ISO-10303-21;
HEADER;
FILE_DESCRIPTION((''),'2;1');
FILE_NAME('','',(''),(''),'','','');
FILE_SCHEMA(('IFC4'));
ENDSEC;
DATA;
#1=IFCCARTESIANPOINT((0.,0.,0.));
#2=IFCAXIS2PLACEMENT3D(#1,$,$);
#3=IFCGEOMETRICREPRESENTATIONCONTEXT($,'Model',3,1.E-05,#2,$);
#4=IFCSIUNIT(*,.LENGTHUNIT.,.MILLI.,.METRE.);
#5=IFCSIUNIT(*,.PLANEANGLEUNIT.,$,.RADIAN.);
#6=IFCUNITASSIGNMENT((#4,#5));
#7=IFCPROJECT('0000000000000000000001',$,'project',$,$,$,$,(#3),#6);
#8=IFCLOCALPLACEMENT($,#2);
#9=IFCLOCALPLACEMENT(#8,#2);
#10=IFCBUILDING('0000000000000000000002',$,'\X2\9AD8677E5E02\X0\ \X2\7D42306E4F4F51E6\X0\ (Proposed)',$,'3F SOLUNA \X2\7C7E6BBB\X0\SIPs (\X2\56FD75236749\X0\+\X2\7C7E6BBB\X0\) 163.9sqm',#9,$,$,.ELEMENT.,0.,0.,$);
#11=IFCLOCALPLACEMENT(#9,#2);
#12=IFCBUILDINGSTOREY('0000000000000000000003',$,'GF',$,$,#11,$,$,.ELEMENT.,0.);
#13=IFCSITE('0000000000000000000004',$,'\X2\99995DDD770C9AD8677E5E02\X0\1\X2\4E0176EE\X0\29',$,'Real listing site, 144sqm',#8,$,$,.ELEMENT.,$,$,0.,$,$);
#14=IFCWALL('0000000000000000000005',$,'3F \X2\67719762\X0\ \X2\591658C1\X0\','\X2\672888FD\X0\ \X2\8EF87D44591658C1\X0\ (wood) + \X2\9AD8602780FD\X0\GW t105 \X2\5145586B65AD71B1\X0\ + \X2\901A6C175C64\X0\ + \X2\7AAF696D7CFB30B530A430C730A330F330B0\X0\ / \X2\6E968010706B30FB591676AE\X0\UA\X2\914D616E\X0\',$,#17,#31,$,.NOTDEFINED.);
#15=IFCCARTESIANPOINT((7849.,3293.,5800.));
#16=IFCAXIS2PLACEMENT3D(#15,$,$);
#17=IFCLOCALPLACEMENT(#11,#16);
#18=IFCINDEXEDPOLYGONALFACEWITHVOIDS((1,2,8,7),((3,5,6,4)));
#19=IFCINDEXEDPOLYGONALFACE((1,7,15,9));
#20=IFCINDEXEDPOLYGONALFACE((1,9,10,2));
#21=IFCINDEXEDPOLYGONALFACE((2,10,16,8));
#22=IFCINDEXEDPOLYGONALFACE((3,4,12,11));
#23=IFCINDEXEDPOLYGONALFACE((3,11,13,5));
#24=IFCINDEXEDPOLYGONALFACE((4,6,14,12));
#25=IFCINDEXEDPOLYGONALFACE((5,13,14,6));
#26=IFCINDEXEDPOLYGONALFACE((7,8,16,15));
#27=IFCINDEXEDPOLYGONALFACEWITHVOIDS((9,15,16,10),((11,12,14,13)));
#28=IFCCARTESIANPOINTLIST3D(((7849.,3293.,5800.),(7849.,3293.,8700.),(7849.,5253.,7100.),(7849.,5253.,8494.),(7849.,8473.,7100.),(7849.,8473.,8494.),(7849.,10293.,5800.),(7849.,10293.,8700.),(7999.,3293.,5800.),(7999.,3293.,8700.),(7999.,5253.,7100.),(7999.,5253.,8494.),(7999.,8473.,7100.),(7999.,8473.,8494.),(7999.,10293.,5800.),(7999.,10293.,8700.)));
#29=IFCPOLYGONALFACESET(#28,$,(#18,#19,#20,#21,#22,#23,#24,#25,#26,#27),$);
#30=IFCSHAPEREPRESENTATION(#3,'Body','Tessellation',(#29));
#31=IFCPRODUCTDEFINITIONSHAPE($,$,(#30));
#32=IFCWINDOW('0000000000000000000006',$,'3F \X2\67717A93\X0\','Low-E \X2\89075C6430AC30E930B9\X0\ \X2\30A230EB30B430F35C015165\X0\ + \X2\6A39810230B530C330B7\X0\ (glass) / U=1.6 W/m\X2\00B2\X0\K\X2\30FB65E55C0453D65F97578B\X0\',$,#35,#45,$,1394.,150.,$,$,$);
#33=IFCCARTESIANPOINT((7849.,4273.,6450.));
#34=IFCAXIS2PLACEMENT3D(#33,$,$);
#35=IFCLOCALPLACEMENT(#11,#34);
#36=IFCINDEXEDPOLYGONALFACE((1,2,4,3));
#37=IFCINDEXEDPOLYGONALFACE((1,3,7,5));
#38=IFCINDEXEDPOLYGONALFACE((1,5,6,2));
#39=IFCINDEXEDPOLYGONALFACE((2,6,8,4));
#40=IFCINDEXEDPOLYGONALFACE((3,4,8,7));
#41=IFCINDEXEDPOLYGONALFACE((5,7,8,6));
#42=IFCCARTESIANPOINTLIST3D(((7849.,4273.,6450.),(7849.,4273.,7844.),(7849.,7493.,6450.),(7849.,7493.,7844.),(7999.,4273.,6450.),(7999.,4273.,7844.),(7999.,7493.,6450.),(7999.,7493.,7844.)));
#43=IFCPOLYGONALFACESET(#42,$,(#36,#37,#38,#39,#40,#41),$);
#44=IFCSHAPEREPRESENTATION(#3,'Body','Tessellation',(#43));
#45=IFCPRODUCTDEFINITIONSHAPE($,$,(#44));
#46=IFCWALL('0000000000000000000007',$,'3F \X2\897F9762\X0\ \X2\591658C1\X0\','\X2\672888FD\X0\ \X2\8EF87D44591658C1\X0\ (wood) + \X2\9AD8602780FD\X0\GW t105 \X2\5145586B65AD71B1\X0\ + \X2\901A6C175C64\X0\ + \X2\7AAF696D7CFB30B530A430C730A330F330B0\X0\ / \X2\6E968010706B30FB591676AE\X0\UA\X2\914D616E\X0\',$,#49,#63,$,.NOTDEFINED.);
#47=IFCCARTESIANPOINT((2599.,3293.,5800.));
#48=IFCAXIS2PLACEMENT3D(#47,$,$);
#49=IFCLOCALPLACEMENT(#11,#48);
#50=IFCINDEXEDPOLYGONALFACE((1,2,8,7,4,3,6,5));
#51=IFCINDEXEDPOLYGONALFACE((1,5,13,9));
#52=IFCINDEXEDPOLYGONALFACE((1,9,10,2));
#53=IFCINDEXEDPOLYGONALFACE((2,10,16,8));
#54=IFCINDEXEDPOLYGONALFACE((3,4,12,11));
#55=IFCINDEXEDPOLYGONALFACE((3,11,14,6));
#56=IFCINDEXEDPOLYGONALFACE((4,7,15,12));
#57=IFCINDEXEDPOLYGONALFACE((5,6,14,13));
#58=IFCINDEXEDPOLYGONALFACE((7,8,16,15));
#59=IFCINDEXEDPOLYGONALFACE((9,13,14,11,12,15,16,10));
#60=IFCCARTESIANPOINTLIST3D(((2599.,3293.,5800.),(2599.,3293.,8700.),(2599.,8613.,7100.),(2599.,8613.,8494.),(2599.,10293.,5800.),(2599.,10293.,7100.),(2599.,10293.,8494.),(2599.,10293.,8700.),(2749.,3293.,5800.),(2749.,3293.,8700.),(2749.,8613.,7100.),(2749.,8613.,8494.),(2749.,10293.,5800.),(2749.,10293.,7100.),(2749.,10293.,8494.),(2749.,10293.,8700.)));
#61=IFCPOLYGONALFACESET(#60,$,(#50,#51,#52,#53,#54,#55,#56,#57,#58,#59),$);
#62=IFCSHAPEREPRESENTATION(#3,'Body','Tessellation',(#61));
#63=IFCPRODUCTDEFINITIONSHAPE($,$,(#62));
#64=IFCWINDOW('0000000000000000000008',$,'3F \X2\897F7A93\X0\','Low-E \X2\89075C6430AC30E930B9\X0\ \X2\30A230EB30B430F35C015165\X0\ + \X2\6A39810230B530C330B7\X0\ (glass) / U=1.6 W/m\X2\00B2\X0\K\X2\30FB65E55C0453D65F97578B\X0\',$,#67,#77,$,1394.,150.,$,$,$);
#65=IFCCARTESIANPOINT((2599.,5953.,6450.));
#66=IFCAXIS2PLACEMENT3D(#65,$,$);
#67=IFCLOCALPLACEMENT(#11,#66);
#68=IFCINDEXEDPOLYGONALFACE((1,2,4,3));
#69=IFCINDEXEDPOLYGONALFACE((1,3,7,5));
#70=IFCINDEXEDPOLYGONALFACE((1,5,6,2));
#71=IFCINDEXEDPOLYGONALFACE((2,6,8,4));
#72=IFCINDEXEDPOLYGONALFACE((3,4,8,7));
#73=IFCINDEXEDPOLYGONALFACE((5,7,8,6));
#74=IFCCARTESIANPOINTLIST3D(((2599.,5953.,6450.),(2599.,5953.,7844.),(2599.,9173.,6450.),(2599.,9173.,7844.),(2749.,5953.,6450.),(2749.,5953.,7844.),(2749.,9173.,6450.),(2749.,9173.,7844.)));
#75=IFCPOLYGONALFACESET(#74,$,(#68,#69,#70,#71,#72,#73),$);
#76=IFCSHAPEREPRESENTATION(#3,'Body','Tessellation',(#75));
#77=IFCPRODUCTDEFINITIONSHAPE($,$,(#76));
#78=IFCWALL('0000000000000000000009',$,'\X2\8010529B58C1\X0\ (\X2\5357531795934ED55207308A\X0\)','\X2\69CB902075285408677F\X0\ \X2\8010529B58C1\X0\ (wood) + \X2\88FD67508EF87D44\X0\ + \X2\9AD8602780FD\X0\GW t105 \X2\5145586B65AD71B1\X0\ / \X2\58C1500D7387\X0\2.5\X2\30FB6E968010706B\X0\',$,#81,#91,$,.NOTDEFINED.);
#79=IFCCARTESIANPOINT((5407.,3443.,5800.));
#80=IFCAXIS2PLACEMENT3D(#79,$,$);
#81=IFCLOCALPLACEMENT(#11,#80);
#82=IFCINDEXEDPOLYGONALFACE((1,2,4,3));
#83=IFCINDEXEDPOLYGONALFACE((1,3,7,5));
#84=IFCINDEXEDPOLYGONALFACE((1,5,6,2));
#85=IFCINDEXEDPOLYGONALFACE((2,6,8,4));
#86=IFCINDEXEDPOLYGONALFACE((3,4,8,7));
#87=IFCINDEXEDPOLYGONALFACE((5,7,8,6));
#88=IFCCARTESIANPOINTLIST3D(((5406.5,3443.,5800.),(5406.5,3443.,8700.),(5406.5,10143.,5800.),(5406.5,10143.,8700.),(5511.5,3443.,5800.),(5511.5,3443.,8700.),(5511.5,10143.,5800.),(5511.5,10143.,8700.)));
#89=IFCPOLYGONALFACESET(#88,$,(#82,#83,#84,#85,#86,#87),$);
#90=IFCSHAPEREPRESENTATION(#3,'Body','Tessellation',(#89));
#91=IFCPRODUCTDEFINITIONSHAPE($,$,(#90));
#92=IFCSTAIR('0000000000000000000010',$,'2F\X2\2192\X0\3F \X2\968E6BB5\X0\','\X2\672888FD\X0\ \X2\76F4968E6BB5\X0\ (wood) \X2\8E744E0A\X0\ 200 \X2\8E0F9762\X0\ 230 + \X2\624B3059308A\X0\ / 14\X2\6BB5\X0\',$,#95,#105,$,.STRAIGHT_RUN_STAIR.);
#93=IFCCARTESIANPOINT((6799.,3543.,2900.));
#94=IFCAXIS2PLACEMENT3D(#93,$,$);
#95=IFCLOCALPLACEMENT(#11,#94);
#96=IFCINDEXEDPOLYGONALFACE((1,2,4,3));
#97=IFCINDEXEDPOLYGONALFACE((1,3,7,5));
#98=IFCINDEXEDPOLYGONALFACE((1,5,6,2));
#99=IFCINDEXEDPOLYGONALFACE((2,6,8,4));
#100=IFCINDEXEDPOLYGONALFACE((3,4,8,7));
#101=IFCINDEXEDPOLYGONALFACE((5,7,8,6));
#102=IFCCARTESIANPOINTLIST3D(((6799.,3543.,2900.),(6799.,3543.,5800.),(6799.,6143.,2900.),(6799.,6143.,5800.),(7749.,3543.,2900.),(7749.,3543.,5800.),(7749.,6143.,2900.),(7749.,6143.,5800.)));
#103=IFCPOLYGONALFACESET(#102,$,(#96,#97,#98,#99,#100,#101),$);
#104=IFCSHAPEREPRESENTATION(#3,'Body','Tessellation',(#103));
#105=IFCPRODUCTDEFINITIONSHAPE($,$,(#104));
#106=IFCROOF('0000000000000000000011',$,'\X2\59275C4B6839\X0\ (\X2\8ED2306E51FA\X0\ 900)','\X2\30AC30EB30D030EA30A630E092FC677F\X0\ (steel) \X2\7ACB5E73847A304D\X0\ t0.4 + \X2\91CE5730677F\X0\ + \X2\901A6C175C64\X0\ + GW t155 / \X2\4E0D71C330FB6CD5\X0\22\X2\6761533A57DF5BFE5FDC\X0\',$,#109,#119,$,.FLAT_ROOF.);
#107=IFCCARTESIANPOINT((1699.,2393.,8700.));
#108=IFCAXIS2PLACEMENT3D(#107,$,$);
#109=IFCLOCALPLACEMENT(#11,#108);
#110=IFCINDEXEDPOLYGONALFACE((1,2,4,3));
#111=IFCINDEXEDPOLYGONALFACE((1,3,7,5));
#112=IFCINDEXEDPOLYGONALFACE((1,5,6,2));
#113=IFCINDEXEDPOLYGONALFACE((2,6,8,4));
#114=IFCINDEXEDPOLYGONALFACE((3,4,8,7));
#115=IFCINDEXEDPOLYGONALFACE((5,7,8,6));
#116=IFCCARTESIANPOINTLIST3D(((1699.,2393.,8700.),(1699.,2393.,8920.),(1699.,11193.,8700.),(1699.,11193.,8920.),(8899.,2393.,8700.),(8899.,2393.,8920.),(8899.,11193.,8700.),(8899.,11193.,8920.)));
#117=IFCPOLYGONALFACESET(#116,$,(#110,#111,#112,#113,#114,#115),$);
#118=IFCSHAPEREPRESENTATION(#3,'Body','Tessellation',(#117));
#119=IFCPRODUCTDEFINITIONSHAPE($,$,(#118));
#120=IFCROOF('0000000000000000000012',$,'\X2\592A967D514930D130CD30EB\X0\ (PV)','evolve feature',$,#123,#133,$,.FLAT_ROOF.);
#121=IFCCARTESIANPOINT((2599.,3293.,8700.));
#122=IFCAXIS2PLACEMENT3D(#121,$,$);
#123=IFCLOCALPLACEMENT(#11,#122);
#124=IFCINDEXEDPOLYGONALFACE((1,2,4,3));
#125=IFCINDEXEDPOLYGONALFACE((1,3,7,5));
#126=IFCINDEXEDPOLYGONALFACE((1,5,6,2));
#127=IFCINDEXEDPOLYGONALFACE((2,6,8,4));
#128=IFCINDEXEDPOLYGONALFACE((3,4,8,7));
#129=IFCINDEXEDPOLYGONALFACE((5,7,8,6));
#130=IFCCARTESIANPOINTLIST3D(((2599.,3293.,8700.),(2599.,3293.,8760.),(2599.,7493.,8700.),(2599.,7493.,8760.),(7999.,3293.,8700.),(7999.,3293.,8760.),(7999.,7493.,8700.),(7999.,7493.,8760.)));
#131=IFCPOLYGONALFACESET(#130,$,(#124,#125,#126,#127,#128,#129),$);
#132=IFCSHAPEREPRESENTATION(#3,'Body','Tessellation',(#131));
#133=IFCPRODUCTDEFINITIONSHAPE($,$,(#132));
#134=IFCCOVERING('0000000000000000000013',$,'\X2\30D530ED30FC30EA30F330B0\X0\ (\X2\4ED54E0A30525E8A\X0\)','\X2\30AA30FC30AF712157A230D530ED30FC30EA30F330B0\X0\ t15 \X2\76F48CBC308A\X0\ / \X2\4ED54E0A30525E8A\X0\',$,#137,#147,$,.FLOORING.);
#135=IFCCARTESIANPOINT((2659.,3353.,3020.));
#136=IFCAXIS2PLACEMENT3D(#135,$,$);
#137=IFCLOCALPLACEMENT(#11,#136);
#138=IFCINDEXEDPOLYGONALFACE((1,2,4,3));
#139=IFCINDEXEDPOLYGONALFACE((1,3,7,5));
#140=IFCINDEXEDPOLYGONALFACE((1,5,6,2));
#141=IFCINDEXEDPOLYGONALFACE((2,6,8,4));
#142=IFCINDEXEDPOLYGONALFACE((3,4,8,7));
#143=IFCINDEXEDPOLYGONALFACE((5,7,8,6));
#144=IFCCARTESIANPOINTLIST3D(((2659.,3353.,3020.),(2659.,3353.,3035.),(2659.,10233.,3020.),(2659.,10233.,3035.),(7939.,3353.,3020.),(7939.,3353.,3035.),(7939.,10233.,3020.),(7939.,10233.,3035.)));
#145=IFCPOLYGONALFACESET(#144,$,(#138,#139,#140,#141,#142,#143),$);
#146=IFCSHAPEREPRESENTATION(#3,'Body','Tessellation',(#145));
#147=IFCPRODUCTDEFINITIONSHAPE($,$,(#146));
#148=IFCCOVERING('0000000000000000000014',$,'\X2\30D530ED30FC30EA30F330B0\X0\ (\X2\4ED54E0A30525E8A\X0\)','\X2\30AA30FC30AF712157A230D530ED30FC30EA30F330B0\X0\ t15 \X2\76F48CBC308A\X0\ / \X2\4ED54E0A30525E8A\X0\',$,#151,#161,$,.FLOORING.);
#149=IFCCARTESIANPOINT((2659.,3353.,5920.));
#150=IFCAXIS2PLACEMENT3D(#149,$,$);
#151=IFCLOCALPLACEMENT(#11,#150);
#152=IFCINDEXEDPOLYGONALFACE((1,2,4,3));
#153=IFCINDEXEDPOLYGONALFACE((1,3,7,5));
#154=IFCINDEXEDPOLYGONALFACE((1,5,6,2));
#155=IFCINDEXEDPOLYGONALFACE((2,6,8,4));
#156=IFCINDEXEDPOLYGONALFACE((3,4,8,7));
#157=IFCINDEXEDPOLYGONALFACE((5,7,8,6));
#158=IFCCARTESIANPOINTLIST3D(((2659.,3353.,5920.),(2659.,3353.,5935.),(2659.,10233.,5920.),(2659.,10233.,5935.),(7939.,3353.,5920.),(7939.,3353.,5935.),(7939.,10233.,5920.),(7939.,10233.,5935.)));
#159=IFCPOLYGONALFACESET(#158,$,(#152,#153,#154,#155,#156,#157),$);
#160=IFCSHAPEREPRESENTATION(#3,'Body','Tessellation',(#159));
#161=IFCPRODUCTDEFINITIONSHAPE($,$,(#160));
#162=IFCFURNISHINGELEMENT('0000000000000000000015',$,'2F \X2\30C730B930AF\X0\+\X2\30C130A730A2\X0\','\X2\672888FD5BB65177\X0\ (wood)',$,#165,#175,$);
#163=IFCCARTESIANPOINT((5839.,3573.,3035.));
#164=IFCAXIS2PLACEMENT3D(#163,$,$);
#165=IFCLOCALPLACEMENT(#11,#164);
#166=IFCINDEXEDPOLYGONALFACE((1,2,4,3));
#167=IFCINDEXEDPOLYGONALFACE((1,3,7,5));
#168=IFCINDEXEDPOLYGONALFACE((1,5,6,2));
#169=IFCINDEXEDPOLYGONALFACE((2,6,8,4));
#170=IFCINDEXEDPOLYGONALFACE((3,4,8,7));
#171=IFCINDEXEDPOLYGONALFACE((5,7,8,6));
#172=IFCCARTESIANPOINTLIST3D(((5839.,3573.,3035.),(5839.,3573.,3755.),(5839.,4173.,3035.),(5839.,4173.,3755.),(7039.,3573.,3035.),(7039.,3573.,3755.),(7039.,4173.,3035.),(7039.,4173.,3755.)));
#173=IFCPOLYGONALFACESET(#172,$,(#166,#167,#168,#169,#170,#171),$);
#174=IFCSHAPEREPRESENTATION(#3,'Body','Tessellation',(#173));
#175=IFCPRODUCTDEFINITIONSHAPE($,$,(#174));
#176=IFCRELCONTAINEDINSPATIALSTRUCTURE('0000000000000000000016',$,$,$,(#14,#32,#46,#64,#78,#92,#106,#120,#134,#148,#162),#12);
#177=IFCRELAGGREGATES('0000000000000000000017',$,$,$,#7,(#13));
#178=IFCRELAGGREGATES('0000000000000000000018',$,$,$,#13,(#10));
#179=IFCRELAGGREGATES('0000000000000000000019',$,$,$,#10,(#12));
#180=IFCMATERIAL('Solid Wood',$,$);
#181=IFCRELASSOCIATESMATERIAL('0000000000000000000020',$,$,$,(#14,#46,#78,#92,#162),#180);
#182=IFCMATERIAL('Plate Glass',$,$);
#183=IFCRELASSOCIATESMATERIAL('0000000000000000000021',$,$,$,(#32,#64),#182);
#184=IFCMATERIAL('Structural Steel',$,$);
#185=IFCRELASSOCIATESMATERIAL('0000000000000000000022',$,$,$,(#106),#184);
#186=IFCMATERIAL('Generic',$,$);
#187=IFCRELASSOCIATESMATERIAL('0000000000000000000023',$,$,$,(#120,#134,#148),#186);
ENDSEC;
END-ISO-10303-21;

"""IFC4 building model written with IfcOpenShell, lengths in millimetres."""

from ifc_helpers import new_model, si_unit, frame, frame_2d, origin, place, context, project, spatial, rectangle, extrude, material, element, fill, save


model = new_model("IFC4")

# Units and contexts
model_context = context("Model", 3, precision=1e-05, world=origin())
ifc_project = project(units=[si_unit("LENGTHUNIT", "METRE", prefix="MILLI"), si_unit("PLANEANGLEUNIT", "RADIAN")], contexts=[model_context])

# Site, building, storey
site_placement = place(None, origin())
site = spatial("IfcSite", under=ifc_project, at=site_placement, Name="香川県高松市1丁目29", ObjectType="Real listing site, 144sqm", CompositionType="ELEMENT", RefElevation=0.0)
building_placement = place(site_placement, origin())
building = spatial("IfcBuilding", under=site, at=building_placement, Name="高松市 終の住処 (Proposed)", ObjectType="3F SOLUNA 籾殻SIPs (国産杉+籾殻) 163.9sqm", CompositionType="ELEMENT", ElevationOfRefHeight=0.0, ElevationOfTerrain=0.0)
storey_placement = place(building_placement, origin())
storey = spatial("IfcBuildingStorey", under=building, at=storey_placement, Name="GF", CompositionType="ELEMENT", Elevation=0.0)

# Shared definitions
ifc_material_1 = material(Name="Solid Wood")

# Shared definitions
ifc_material_2 = material(Name="Plate Glass")

# Shared definitions
ifc_material_3 = material(Name="Generic")

# Walls, openings, windows
wall_1_placement = place(storey_placement, frame((7849.0, 3293.0, 5800.0)))
wall_1 = element("IfcWall", 1, at=wall_1_placement, inside=storey, material=ifc_material_1, Name="3F 東面 外壁", Description="木製 軸組外壁 (wood) + 高性能GW t105 充填断熱 + 通気層 + 窯業系サイディング / 準耐火・外皮UA配慮", PredefinedType="NOTDEFINED", context=model_context, shape_type="SweptSolid", body=[
    extrude(rectangle(XDim=150.0, YDim=7000.0, at=frame_2d((75.0, 3500.0))), frame((7849.0, 3293.0, 5800.0)), (0.0, 0.0, 1.0), 2900.0),
])
opening_1_placement = place(storey_placement, frame((7849.0, 4273.0, 6450.0)))
opening_1 = element("IfcOpeningElement", 2, at=opening_1_placement, cuts=wall_1, PredefinedType="NOTDEFINED", context=model_context, shape_type="SweptSolid", body=[
    extrude(rectangle(XDim=150.0, YDim=3220.0, at=frame_2d((75.0, 1610.0))), frame((7849.0, 4273.0, 6450.0)), (0.0, 0.0, 1.0), 1394.0),
])
window_1_placement = place(storey_placement, frame((7849.0, 4273.0, 6450.0)))
window_1 = element("IfcWindow", 3, at=window_1_placement, inside=storey, material=ifc_material_2, Name="3F 東窓", Description="Low-E 複層ガラス アルゴン封入 + 樹脂サッシ (glass) / U=1.6 W/m²K・日射取得型", OverallHeight=1394.0, OverallWidth=150.0, context=model_context, shape_type="SweptSolid", body=[
    extrude(rectangle(XDim=150.0, YDim=3220.0, at=frame_2d((75.0, 1610.0))), frame((7849.0, 4273.0, 6450.0)), (0.0, 0.0, 1.0), 1394.0),
])
fill(opening_1, window_1)
wall_2_placement = place(storey_placement, frame((2599.0, 3293.0, 5800.0)))
wall_2 = element("IfcWall", 4, at=wall_2_placement, inside=storey, material=ifc_material_1, Name="3F 西面 外壁", Description="木製 軸組外壁 (wood) + 高性能GW t105 充填断熱 + 通気層 + 窯業系サイディング / 準耐火・外皮UA配慮", PredefinedType="NOTDEFINED", context=model_context, shape_type="SweptSolid", body=[
    extrude(rectangle(XDim=150.0, YDim=7000.0, at=frame_2d((75.0, 3500.0))), frame((2599.0, 3293.0, 5800.0)), (0.0, 0.0, 1.0), 2900.0),
])
opening_2_placement = place(storey_placement, frame((2599.0, 5953.0, 6450.0)))
opening_2 = element("IfcOpeningElement", 5, at=opening_2_placement, cuts=wall_2, PredefinedType="NOTDEFINED", context=model_context, shape_type="SweptSolid", body=[
    extrude(rectangle(XDim=150.0, YDim=3220.0, at=frame_2d((75.0, 1610.0))), frame((2599.0, 5953.0, 6450.0)), (0.0, 0.0, 1.0), 1394.0),
])
window_2_placement = place(storey_placement, frame((2599.0, 5953.0, 6450.0)))
window_2 = element("IfcWindow", 6, at=window_2_placement, inside=storey, material=ifc_material_2, Name="3F 西窓", Description="Low-E 複層ガラス アルゴン封入 + 樹脂サッシ (glass) / U=1.6 W/m²K・日射取得型", OverallHeight=1394.0, OverallWidth=150.0, context=model_context, shape_type="SweptSolid", body=[
    extrude(rectangle(XDim=150.0, YDim=3220.0, at=frame_2d((75.0, 1610.0))), frame((2599.0, 5953.0, 6450.0)), (0.0, 0.0, 1.0), 1394.0),
])
fill(opening_2, window_2)

# Wall
wall_3_placement = place(storey_placement, frame((5407.0, 3443.0, 5800.0)))
element("IfcWall", 7, at=wall_3_placement, inside=storey, material=ifc_material_1, Name="耐力壁 (南北間仕切り)", Description="構造用合板 耐力壁 (wood) + 製材軸組 + 高性能GW t105 充填断熱 / 壁倍率2.5・準耐火", PredefinedType="NOTDEFINED", context=model_context, shape_type="SweptSolid", body=[
    extrude(rectangle(XDim=105.0, YDim=6700.0, at=frame_2d((52.0, 3350.0))), frame((5407.0, 3443.0, 5800.0)), (0.0, 0.0, 1.0), 2900.0),
])

# Stair
stair_placement = place(storey_placement, frame((6799.0, 3543.0, 2900.0)))
element("IfcStair", 8, at=stair_placement, inside=storey, material=ifc_material_1, Name="2F→3F 階段", Description="木製 直階段 (wood) 蹴上 200 踏面 230 + 手すり / 14段", PredefinedType="STRAIGHT_RUN_STAIR", context=model_context, shape_type="SweptSolid", body=[
    extrude(rectangle(XDim=950.0, YDim=2600.0, at=frame_2d((475.0, 1300.0))), frame((6799.0, 3543.0, 2900.0)), (0.0, 0.0, 1.0), 2900.0),
])

# Roofs
ifc_material_4 = material(Name="Structural Steel")
roof_1_placement = place(storey_placement, frame((1699.0, 2393.0, 8700.0)))
element("IfcRoof", 9, at=roof_1_placement, inside=storey, material=ifc_material_4, Name="大屋根 (軒の出 900)", Description="ガルバリウム鋼板 (steel) 立平葺き t0.4 + 野地板 + 通気層 + GW t155 / 不燃・法22条区域対応", PredefinedType="FLAT_ROOF", context=model_context, shape_type="SweptSolid", body=[
    extrude(rectangle(XDim=7200.0, YDim=8800.0, at=frame_2d((3600.0, 4400.0))), frame((1699.0, 2393.0, 8700.0)), (0.0, 0.0, 1.0), 220.0),
])
roof_2_placement = place(storey_placement, frame((2599.0, 3293.0, 8700.0)))
element("IfcRoof", 10, at=roof_2_placement, inside=storey, material=ifc_material_3, Name="太陽光パネル (PV)", Description="evolve feature", PredefinedType="FLAT_ROOF", context=model_context, shape_type="SweptSolid", body=[
    extrude(rectangle(XDim=5400.0, YDim=4200.0, at=frame_2d((2700.0, 2100.0))), frame((2599.0, 3293.0, 8700.0)), (0.0, 0.0, 1.0), 60.0),
])

# Coverings
covering_1_placement = place(storey_placement, frame((2659.0, 3353.0, 3020.0)))
element("IfcCovering", 11, at=covering_1_placement, inside=storey, material=ifc_material_3, Name="フローリング (仕上げ床)", Description="オーク無垢フローリング t15 直貼り / 仕上げ床", PredefinedType="FLOORING", context=model_context, shape_type="SweptSolid", body=[
    extrude(rectangle(XDim=5280.0, YDim=6880.0, at=frame_2d((2640.0, 3440.0))), frame((2659.0, 3353.0, 3020.0)), (0.0, 0.0, 1.0), 15.0),
])
covering_2_placement = place(storey_placement, frame((2659.0, 3353.0, 5920.0)))
element("IfcCovering", 12, at=covering_2_placement, inside=storey, material=ifc_material_3, Name="フローリング (仕上げ床)", Description="オーク無垢フローリング t15 直貼り / 仕上げ床", PredefinedType="FLOORING", context=model_context, shape_type="SweptSolid", body=[
    extrude(rectangle(XDim=5280.0, YDim=6880.0, at=frame_2d((2640.0, 3440.0))), frame((2659.0, 3353.0, 5920.0)), (0.0, 0.0, 1.0), 15.0),
])

# Furnishing element
furnishing_placement = place(storey_placement, frame((5839.0, 3573.0, 3035.0)))
element("IfcFurnishingElement", 13, at=furnishing_placement, inside=storey, material=ifc_material_1, Name="2F デスク+チェア", Description="木製家具 (wood)", context=model_context, shape_type="SweptSolid", body=[
    extrude(rectangle(XDim=1200.0, YDim=600.0, at=frame_2d((600.0, 300.0))), frame((5839.0, 3573.0, 3035.0)), (0.0, 0.0, 1.0), 720.0),
])

save(model, "model.ifc")
